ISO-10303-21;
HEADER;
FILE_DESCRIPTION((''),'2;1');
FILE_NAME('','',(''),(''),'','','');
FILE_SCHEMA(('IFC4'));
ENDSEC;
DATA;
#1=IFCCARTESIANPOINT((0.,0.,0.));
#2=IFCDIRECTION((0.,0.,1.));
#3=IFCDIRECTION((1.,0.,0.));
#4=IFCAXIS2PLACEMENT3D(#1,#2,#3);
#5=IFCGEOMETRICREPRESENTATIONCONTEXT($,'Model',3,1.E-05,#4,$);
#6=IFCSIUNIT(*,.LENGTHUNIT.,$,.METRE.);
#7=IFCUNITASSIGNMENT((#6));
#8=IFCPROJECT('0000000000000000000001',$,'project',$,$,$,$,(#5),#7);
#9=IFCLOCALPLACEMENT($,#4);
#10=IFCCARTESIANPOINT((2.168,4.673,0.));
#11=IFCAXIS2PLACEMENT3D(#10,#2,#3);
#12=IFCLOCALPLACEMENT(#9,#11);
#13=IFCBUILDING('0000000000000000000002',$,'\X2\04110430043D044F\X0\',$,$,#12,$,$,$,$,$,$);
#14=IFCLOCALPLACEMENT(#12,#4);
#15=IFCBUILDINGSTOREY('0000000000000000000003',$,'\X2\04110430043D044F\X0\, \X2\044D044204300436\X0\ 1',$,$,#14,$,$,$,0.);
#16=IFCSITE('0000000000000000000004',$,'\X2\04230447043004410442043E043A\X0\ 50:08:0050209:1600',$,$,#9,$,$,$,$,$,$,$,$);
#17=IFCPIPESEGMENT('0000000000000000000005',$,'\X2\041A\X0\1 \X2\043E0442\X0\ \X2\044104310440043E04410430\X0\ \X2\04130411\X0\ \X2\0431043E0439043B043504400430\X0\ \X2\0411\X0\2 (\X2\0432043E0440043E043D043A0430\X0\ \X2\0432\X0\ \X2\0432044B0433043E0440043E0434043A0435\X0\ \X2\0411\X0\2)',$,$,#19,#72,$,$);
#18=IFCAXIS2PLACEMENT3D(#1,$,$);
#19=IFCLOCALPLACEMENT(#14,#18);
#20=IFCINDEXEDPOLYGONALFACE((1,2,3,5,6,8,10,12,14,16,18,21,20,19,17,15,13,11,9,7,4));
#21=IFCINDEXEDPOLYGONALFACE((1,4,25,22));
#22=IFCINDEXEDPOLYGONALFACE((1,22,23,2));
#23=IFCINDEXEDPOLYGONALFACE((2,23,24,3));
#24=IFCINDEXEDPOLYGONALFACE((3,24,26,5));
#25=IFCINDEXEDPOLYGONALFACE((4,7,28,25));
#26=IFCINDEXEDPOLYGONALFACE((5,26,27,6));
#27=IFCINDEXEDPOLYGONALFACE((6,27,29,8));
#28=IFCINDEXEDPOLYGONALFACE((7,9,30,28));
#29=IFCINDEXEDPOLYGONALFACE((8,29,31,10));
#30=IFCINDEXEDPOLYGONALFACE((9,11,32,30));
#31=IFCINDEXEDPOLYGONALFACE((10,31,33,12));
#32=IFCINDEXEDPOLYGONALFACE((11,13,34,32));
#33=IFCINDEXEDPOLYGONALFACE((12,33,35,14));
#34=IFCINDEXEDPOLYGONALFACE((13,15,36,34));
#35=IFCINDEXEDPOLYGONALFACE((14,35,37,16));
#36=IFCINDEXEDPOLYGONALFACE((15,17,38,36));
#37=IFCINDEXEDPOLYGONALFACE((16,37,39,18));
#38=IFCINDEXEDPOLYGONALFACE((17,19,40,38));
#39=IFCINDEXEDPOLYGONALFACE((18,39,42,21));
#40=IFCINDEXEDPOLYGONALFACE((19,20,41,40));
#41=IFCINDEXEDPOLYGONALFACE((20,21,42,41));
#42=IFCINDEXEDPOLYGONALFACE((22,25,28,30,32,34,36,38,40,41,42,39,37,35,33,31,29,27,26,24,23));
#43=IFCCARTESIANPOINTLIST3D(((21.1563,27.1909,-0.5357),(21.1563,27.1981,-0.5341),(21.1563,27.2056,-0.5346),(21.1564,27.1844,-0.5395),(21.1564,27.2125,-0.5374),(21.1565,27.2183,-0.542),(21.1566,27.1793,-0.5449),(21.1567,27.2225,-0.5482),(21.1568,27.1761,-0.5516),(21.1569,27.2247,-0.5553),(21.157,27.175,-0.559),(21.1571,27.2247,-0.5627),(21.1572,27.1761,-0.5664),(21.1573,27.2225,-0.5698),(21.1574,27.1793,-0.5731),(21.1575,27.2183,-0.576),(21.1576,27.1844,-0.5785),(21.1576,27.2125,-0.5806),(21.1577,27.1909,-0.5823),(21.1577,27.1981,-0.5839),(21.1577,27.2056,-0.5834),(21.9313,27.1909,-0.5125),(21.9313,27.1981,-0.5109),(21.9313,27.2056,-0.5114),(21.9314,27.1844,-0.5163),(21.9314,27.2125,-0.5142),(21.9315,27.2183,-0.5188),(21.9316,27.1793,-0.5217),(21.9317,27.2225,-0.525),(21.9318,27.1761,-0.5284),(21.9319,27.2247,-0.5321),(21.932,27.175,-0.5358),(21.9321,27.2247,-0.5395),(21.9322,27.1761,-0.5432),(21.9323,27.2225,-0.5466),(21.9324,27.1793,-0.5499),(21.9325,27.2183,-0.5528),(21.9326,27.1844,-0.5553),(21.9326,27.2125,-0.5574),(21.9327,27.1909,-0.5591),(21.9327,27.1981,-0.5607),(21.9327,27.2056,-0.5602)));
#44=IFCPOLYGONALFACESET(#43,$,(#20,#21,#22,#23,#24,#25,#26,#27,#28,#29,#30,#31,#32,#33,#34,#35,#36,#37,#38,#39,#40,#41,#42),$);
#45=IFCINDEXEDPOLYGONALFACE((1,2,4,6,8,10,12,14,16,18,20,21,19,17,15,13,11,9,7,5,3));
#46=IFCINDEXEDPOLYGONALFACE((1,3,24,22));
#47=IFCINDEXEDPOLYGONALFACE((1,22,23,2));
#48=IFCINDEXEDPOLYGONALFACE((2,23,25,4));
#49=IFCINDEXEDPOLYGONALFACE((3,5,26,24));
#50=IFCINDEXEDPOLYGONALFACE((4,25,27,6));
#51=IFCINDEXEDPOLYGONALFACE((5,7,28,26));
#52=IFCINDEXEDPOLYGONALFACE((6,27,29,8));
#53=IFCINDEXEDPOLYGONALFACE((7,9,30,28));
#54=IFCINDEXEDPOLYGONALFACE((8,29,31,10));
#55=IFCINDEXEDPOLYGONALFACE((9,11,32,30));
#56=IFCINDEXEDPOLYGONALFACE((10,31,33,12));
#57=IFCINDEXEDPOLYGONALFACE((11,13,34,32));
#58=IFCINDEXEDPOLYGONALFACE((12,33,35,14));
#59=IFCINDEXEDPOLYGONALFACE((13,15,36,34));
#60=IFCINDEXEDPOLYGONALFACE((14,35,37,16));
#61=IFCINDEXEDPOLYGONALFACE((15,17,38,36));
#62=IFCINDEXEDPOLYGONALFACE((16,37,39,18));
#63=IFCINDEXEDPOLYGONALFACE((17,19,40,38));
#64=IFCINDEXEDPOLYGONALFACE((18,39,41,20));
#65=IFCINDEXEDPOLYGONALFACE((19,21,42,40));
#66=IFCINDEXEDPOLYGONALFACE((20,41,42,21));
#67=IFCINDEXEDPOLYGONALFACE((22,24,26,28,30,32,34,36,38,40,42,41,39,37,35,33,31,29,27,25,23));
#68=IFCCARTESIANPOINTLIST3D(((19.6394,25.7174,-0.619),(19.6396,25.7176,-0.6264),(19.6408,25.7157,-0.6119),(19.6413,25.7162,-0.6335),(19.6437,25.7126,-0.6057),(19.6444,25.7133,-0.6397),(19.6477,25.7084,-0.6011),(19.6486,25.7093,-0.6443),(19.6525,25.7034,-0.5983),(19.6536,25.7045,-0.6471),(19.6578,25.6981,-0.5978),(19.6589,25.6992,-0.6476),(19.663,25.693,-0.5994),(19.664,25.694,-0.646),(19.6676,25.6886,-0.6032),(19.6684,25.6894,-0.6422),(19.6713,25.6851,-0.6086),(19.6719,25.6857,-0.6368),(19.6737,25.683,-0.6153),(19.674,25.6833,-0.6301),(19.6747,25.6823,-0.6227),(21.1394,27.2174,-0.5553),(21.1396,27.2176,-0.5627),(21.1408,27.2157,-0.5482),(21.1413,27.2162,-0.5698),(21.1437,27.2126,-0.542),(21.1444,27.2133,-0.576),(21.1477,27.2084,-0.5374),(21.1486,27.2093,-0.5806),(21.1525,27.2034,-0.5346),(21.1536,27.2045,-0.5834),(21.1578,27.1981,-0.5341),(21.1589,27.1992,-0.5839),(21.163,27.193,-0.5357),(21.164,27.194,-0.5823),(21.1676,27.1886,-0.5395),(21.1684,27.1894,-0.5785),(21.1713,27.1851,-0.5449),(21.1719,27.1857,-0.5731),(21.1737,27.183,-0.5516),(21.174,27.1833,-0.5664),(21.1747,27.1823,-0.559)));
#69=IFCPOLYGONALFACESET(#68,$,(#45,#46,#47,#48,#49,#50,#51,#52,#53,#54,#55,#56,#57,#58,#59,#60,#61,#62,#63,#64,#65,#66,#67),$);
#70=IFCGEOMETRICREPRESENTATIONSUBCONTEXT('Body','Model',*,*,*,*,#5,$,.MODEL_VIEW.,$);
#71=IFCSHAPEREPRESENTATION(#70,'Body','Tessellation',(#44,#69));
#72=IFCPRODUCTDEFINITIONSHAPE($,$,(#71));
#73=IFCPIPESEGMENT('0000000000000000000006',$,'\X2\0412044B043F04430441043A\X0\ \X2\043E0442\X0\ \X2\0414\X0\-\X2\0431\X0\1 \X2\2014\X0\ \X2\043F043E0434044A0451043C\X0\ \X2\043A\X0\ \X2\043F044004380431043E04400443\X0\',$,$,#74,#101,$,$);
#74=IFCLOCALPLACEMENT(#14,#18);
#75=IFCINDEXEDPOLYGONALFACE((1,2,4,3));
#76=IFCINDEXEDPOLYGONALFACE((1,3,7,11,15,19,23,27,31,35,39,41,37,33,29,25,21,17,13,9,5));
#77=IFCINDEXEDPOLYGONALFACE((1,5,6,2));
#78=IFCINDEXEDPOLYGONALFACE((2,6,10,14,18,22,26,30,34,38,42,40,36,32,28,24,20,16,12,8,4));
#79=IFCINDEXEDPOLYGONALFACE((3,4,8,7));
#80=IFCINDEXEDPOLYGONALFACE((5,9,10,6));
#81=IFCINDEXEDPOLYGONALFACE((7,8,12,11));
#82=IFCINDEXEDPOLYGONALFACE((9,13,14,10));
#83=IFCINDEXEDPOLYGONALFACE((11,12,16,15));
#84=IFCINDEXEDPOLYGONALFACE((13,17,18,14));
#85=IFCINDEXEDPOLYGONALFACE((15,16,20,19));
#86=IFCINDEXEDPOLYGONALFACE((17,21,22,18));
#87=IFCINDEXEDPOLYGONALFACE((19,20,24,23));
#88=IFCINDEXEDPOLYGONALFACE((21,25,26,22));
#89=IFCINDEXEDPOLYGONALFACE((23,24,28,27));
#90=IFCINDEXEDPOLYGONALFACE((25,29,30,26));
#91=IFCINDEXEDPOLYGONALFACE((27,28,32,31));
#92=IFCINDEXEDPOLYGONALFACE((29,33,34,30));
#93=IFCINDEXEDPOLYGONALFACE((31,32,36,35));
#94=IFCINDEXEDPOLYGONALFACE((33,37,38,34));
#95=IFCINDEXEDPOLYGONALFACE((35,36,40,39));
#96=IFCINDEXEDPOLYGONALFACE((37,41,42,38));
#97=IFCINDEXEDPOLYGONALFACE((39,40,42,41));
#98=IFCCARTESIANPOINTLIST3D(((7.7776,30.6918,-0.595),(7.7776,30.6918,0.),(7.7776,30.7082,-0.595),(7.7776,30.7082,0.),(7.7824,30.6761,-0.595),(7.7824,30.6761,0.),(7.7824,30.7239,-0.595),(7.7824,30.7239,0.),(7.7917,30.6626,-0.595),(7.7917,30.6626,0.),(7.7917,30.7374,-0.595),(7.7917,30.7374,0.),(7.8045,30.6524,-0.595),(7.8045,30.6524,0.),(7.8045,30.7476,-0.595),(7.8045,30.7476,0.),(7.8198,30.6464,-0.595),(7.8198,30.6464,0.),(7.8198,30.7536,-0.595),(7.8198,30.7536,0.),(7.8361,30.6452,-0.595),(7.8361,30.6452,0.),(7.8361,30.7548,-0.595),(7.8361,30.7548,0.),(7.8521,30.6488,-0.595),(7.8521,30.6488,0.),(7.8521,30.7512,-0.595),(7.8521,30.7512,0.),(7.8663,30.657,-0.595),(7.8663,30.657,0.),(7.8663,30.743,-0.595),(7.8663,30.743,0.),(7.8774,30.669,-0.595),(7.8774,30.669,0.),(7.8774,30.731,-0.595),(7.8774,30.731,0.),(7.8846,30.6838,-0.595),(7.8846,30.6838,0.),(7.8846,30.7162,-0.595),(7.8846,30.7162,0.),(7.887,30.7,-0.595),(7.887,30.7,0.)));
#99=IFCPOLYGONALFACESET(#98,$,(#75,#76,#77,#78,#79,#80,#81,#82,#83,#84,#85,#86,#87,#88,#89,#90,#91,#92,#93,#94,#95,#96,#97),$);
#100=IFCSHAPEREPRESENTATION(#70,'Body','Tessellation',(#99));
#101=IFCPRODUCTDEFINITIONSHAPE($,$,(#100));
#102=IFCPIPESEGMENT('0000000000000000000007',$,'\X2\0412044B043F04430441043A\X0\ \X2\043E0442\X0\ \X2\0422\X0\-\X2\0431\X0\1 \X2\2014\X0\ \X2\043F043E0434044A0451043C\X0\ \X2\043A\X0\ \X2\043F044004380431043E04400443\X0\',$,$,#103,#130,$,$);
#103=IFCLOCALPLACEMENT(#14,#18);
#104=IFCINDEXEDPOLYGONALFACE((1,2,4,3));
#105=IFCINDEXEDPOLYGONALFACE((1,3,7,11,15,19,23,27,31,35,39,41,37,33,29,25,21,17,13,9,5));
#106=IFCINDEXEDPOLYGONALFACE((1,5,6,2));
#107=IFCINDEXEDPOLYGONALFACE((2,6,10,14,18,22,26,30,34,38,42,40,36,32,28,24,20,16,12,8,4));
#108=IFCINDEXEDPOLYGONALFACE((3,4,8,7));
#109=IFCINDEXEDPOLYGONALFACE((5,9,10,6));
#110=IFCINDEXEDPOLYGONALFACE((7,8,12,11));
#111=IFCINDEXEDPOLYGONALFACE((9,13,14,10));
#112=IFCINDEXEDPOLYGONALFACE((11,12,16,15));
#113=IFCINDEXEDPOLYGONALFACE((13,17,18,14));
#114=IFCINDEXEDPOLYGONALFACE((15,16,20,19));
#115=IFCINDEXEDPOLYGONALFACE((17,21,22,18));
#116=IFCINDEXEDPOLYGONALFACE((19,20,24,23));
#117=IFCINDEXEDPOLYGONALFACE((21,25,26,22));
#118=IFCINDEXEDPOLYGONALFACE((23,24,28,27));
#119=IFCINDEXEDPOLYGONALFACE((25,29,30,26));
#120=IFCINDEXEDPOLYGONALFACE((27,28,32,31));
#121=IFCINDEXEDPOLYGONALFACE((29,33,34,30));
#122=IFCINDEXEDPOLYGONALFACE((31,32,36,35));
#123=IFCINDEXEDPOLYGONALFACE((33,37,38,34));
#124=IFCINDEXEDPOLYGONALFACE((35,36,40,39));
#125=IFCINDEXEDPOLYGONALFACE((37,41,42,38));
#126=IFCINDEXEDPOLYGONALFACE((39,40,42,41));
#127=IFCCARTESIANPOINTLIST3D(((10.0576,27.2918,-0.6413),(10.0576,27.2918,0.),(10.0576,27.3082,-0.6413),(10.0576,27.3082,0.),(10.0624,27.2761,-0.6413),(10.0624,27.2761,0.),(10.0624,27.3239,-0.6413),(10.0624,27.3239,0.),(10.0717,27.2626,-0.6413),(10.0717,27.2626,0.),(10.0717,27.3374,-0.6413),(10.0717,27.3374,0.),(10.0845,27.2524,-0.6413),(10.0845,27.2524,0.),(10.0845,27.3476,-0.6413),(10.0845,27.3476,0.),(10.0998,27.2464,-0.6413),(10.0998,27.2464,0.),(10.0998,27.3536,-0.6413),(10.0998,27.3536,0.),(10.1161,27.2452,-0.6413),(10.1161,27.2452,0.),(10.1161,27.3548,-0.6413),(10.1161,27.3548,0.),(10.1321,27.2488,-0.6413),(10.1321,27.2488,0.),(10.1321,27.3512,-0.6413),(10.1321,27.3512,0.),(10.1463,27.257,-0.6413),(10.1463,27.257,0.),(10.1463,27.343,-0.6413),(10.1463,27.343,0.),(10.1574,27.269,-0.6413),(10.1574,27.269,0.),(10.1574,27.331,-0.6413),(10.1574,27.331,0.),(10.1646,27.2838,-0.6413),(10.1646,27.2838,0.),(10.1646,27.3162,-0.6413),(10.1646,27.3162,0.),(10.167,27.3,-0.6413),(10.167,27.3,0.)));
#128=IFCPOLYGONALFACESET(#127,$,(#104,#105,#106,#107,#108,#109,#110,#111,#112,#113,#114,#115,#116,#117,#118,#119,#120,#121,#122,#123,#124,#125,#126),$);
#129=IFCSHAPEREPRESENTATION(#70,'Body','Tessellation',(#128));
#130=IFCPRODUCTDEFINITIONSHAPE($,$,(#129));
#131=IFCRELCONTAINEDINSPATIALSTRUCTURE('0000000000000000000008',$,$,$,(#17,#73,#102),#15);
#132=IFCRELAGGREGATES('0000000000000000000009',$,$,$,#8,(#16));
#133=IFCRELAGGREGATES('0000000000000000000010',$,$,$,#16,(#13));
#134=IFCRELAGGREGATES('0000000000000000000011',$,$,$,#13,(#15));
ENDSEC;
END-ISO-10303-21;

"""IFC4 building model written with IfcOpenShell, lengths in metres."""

from ifc_helpers import new_model, si_unit, frame, origin_with_axes, origin_2d, place, context, subcontext, project, spatial, circle, extrude, element, save


model = new_model("IFC4")

# Units and contexts
model_context = context("Model", 3, precision=1e-05, world=origin_with_axes())
body_context = subcontext(model_context, "Body", "Model", "MODEL_VIEW")
ifc_project = project(units=[si_unit("LENGTHUNIT", "METRE")], contexts=[model_context])

# Site, building, storey
site_placement = place(None, origin_with_axes())
site = spatial("IfcSite", under=ifc_project, at=site_placement, Name="Участок 50:08:0050209:1600")
building_placement = place(site_placement, frame((2.168, 4.673, 0.0), z_axis=(0.0, 0.0, 1.0), x_axis=(1.0, 0.0, 0.0)))
building = spatial("IfcBuilding", under=site, at=building_placement, Name="Баня")
storey_placement = place(building_placement, origin_with_axes())
storey = spatial("IfcBuildingStorey", under=building, at=storey_placement, Name="Баня, этаж 1", Elevation=0.0)

# Pipe segments
pipe_segment_1_placement = place(storey_placement, origin_with_axes())
element("IfcPipeSegment", 1, at=pipe_segment_1_placement, inside=storey, Name="К1 от сброса ГБ бойлера Б2 (воронка в выгородке Б2)", context=body_context, shape_type="SweptSolid", body=[
    extrude(circle(Radius=0.025, at=origin_2d()), frame((21.932, 27.2, -0.5358), z_axis=(-0.999552, 0.0, -0.029922), x_axis=(0.0, -1.0, 0.0)), (0.0, 0.0, 1.0), 0.7753),
    extrude(circle(Radius=0.025, at=origin_2d()), frame((21.157, 27.2, -0.559), z_axis=(-0.706788, -0.706788, -0.030015), x_axis=(0.707107, -0.707107, 0.0)), (0.0, 0.0, 1.0), 2.1223),
])
pipe_segment_2_placement = place(storey_placement, origin_with_axes())
element("IfcPipeSegment", 2, at=pipe_segment_2_placement, inside=storey, Name="Выпуск от Д-б1 — подъём к прибору", context=body_context, shape_type="SweptSolid", body=[
    extrude(circle(Radius=0.055, at=origin_2d()), frame((7.832, 30.7, 0.0), z_axis=(0.0, 0.0, -1.0), x_axis=(1.0, 0.0, 0.0)), (0.0, 0.0, 1.0), 0.595),
])
pipe_segment_3_placement = place(storey_placement, origin_with_axes())
element("IfcPipeSegment", 3, at=pipe_segment_3_placement, inside=storey, Name="Выпуск от Т-б1 — подъём к прибору", context=body_context, shape_type="SweptSolid", body=[
    extrude(circle(Radius=0.055, at=origin_2d()), frame((10.112, 27.3, 0.0), z_axis=(0.0, 0.0, -1.0), x_axis=(1.0, 0.0, 0.0)), (0.0, 0.0, 1.0), 0.6413),
])

save(model, "model.ifc")
